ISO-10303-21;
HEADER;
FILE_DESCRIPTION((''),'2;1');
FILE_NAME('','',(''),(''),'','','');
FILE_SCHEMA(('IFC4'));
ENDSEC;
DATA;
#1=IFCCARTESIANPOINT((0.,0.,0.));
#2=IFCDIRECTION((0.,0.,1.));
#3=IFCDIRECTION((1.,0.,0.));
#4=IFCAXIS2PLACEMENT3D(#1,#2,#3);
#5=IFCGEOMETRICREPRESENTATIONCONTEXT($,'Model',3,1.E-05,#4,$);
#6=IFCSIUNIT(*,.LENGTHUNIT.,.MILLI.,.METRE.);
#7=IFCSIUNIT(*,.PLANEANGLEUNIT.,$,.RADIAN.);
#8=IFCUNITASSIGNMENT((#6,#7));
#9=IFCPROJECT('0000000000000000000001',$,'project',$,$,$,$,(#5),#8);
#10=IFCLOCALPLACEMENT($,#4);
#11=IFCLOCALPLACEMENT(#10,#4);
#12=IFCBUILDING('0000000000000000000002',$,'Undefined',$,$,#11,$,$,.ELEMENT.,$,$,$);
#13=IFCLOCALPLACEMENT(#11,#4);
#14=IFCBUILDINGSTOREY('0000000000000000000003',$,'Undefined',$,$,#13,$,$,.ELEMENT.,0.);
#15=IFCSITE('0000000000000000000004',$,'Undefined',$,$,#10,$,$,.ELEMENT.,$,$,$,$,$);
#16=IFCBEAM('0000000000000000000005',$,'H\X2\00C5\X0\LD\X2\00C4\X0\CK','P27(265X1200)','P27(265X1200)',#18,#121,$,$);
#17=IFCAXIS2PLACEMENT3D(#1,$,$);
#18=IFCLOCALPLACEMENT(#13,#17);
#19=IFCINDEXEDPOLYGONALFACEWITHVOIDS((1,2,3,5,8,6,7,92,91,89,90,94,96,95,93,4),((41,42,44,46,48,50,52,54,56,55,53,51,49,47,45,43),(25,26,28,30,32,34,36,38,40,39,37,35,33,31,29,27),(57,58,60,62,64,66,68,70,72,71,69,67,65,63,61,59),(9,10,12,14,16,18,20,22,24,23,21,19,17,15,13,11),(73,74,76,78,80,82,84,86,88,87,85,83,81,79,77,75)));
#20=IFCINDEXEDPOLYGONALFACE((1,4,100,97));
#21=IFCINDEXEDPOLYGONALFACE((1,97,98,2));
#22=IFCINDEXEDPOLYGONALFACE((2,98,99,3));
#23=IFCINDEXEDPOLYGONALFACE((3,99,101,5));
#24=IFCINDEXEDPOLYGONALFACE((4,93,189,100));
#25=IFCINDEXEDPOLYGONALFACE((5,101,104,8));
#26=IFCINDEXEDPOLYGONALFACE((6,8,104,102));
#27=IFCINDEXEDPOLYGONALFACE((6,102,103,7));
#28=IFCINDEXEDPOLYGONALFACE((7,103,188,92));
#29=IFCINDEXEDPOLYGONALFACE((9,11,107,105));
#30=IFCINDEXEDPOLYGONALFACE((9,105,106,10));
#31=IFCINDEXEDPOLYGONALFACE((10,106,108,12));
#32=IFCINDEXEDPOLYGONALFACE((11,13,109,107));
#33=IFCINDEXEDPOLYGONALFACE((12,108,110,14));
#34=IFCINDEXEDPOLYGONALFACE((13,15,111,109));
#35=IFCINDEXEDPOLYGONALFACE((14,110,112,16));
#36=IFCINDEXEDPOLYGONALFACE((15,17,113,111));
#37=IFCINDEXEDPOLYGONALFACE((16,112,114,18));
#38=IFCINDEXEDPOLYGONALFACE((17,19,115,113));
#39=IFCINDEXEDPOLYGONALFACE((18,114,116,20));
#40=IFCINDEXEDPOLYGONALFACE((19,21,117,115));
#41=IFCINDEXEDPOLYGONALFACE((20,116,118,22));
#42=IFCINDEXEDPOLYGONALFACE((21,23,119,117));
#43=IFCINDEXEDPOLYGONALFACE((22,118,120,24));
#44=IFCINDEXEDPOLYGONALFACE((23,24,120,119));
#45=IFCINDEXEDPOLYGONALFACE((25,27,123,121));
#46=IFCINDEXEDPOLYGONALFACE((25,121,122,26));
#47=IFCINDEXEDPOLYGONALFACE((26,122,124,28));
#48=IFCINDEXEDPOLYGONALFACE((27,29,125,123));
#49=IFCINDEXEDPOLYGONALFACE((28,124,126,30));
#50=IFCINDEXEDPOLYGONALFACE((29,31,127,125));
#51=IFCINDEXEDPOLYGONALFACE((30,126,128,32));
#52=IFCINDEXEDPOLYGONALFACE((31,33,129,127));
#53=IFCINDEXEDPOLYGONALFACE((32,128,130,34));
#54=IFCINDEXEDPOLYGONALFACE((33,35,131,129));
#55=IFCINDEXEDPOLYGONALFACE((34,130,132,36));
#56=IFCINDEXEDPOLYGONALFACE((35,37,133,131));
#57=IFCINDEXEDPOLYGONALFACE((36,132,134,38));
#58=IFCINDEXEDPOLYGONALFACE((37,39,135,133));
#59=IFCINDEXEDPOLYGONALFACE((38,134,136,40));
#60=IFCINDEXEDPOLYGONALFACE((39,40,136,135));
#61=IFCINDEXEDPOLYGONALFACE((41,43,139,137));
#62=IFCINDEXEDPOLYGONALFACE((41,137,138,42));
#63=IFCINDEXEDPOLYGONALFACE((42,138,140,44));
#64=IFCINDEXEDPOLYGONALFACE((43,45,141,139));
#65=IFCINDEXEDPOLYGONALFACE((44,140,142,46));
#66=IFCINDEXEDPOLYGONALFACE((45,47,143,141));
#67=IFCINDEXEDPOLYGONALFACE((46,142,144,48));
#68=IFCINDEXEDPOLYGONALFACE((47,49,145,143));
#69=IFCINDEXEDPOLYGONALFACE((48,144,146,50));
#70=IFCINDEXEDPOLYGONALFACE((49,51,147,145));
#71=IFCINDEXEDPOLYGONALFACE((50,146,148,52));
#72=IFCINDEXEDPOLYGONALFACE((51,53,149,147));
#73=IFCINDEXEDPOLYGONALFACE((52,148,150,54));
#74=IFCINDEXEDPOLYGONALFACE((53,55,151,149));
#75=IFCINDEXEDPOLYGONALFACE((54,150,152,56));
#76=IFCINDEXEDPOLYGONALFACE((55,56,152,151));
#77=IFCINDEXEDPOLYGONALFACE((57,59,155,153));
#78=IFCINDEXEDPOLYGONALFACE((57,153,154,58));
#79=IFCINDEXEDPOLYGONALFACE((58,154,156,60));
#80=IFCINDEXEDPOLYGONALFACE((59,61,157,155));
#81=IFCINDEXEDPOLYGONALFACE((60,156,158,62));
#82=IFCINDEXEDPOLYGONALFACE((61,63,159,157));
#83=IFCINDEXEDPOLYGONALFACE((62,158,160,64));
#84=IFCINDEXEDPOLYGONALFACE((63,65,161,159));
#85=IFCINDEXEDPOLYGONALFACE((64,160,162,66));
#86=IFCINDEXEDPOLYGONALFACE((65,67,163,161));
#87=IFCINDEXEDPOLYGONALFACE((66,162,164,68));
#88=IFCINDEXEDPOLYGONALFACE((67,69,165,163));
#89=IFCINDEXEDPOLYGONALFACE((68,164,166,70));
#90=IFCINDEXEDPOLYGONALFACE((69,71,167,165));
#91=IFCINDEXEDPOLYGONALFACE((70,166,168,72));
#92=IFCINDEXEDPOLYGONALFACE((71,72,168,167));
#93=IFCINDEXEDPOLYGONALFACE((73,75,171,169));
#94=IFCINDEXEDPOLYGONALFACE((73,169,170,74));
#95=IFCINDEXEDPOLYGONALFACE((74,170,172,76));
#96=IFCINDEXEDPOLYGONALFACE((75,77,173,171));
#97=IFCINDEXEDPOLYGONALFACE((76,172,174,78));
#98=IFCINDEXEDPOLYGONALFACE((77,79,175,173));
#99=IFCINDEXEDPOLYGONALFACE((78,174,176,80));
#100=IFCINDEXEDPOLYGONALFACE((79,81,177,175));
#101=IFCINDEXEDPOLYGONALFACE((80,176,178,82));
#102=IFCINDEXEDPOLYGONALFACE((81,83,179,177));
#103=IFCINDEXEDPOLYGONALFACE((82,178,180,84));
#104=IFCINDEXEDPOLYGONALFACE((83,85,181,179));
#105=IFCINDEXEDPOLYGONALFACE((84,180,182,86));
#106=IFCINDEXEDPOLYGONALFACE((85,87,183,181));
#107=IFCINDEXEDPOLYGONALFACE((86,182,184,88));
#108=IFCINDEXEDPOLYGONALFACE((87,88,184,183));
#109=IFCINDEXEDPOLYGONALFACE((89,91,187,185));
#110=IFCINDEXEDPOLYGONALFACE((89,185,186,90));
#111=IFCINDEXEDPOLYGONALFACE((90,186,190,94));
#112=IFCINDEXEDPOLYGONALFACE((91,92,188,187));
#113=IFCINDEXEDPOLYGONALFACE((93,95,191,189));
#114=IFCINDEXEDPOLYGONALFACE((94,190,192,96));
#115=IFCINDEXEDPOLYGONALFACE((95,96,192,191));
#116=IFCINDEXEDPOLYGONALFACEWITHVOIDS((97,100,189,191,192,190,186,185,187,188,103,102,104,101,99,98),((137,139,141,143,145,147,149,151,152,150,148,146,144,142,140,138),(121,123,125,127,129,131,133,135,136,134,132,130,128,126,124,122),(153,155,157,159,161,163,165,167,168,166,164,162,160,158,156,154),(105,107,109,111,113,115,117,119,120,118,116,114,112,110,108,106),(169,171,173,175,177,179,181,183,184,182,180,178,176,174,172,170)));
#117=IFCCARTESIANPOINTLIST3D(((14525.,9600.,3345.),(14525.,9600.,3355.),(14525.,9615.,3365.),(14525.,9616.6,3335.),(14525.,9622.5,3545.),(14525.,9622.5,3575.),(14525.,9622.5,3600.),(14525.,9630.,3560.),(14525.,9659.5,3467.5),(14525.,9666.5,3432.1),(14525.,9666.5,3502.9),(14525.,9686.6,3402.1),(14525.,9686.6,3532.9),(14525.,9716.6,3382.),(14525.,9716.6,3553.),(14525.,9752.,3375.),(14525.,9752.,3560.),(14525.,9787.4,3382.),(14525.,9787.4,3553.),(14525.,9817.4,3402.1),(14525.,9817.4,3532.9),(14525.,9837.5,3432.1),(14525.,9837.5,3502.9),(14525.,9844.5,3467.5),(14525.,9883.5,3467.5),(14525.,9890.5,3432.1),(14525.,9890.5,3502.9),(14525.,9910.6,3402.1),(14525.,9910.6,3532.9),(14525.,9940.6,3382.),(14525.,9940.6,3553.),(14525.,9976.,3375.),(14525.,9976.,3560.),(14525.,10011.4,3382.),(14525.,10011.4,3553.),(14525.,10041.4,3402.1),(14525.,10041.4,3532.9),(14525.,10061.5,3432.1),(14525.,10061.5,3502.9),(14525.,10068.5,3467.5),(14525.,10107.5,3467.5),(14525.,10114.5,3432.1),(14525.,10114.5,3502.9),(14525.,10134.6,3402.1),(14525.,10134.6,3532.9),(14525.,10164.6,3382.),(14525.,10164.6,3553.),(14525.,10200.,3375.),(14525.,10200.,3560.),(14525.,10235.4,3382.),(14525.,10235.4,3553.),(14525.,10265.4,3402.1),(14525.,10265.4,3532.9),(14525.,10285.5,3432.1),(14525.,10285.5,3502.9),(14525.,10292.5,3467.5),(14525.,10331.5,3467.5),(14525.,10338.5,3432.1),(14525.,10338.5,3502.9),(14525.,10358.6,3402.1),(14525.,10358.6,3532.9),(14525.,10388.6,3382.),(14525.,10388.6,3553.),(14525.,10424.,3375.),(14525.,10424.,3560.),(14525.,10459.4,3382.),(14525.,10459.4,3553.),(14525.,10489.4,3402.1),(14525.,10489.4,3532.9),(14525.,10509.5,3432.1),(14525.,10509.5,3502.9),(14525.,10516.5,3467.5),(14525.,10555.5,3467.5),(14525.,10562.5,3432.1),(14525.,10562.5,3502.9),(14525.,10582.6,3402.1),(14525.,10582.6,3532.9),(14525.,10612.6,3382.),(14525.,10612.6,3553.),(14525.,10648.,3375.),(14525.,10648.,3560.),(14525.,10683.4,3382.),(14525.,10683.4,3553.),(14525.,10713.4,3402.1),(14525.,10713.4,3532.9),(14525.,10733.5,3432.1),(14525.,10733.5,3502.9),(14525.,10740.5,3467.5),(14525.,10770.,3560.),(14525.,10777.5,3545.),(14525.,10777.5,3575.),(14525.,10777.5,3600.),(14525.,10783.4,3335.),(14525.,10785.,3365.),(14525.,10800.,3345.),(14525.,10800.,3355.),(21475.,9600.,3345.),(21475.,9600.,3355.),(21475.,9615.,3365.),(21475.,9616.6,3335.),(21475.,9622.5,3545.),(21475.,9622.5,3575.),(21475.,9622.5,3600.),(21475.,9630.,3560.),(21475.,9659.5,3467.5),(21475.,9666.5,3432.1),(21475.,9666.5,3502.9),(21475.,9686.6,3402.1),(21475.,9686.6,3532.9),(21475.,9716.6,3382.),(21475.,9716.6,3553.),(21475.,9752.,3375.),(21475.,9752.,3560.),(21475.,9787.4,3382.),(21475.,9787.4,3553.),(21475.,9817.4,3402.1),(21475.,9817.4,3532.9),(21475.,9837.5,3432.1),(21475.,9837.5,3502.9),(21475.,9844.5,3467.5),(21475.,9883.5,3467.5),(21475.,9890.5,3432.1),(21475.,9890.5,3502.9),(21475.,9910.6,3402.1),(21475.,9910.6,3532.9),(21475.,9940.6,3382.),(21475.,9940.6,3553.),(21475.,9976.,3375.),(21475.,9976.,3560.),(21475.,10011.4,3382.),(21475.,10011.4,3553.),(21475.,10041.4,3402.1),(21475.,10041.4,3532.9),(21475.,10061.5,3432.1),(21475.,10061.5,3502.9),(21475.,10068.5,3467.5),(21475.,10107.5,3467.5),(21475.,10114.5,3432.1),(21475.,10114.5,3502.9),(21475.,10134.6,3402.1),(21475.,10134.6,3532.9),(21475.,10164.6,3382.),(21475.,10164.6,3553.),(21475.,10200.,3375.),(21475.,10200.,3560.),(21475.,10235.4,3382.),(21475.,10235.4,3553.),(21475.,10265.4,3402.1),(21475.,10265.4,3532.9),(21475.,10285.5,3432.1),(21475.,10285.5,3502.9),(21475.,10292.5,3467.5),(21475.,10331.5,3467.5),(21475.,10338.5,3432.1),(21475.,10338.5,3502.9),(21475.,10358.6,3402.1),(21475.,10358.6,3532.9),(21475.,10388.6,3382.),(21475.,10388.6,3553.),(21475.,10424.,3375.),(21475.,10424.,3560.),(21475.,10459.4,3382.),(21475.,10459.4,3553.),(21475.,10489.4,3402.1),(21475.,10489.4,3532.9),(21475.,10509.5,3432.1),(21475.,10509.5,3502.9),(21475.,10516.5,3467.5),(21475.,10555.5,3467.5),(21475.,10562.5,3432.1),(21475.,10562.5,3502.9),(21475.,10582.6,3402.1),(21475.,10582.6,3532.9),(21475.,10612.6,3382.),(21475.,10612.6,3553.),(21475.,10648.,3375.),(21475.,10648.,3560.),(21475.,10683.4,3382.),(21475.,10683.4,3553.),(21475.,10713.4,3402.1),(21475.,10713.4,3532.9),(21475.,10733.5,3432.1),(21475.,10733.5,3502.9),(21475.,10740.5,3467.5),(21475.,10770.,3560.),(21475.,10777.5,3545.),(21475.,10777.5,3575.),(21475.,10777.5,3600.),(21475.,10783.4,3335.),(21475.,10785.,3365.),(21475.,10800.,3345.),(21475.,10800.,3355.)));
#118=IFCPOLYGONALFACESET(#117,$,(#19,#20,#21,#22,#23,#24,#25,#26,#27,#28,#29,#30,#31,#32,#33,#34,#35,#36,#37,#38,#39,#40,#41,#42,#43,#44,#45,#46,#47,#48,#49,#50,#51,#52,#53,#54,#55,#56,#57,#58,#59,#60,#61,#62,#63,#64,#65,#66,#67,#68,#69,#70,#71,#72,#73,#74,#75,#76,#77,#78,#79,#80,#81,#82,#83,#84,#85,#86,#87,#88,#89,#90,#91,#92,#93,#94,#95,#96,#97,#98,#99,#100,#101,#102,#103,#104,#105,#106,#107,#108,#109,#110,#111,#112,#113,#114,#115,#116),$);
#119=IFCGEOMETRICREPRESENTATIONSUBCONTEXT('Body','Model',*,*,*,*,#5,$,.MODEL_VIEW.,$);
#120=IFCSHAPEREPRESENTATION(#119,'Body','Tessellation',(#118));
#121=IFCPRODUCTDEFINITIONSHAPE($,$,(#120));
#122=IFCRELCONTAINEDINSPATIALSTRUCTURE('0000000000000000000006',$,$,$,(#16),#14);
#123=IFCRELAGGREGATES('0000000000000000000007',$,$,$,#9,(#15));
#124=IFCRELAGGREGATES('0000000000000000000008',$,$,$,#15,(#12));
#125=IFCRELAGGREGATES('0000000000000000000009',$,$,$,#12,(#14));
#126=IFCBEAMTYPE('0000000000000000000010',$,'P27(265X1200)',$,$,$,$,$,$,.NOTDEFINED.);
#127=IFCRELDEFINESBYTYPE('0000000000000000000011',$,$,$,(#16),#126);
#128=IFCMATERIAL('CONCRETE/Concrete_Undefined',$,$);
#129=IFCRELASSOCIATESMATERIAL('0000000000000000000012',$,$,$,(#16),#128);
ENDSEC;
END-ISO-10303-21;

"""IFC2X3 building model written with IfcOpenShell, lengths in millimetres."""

from ifc_helpers import new_model, si_unit, frame, origin_with_axes, place, context, subcontext, project, spatial, polyline, outline, extrude, material, type_object, element, save


model = new_model("IFC2X3")

# Units and contexts
model_context = context("Model", 3, precision=1e-05, world=origin_with_axes())
body_context = subcontext(model_context, "Body", "Model", "MODEL_VIEW")
ifc_project = project(units=[si_unit("LENGTHUNIT", "METRE", prefix="MILLI"), si_unit("PLANEANGLEUNIT", "RADIAN")], contexts=[model_context])

# Site, building, storey
site_placement = place(None, origin_with_axes())
site = spatial("IfcSite", under=ifc_project, at=site_placement, Name="Undefined", CompositionType="ELEMENT")
building_placement = place(site_placement, origin_with_axes())
building = spatial("IfcBuilding", under=site, at=building_placement, Name="Undefined", CompositionType="ELEMENT")
storey_placement = place(building_placement, origin_with_axes())
storey = spatial("IfcBuildingStorey", under=building, at=storey_placement, Name="Undefined", CompositionType="ELEMENT", Elevation=0.0)

# Beam
ifc_material_1 = material(Name="CONCRETE/Concrete_Undefined")
beam_type_1 = type_object("IfcBeamType", Name="P27(265X1200)", PredefinedType="NOTDEFINED")
beam_1_placement = place(storey_placement, frame((14525.0, 10200.0, 3467.5), z_axis=(0.0, 0.0, 1.0), x_axis=(1.0, 0.0, 0.0)))
element("IfcBeam", 1, at=beam_1_placement, inside=storey, type_object=beam_type_1, material=ifc_material_1, Name="HÅLDÄCK", Description="P27(265X1200)", ObjectType="P27(265X1200)", context=body_context, shape_type="SweptSolid", body=[
    extrude(outline(polyline([(-583.4, -132.5), (-600.0, -122.5), (-600.0, -112.5), (-585.0, -102.5), (-577.5, 77.5), (-570.0, 92.5), (-577.5, 107.5), (-577.5, 132.5), (577.5, 132.5), (577.5, 107.5), (570.0, 92.5), (577.5, 77.5), (585.0, -102.5), (600.0, -112.5), (600.0, -122.5), (583.4, -132.5), (-583.4, -132.5)]), holes=[polyline([(-513.4, 65.4), (-533.5, 35.4), (-540.5, 0.0), (-533.5, -35.4), (-513.4, -65.4), (-483.4, -85.5), (-448.0, -92.5), (-412.6, -85.5), (-382.6, -65.4), (-362.5, -35.4), (-355.5, 0.0), (-362.5, 35.4), (-382.6, 65.4), (-412.6, 85.5), (-448.0, 92.5), (-483.4, 85.5), (-513.4, 65.4)]), polyline([(-289.4, 65.4), (-309.5, 35.4), (-316.5, 0.0), (-309.5, -35.4), (-289.4, -65.4), (-259.4, -85.5), (-224.0, -92.5), (-188.6, -85.5), (-158.6, -65.4), (-138.5, -35.4), (-131.5, 0.0), (-138.5, 35.4), (-158.6, 65.4), (-188.6, 85.5), (-224.0, 92.5), (-259.4, 85.5), (-289.4, 65.4)]), polyline([(-65.4, 65.4), (-85.5, 35.4), (-92.5, 0.0), (-85.5, -35.4), (-65.4, -65.4), (-35.4, -85.5), (0.0, -92.5), (35.4, -85.5), (65.4, -65.4), (85.5, -35.4), (92.5, 0.0), (85.5, 35.4), (65.4, 65.4), (35.4, 85.5), (0.0, 92.5), (-35.4, 85.5), (-65.4, 65.4)]), polyline([(158.6, 65.4), (138.5, 35.4), (131.5, 0.0), (138.5, -35.4), (158.6, -65.4), (188.6, -85.5), (224.0, -92.5), (259.4, -85.5), (289.4, -65.4), (309.5, -35.4), (316.5, 0.0), (309.5, 35.4), (289.4, 65.4), (259.4, 85.5), (224.0, 92.5), (188.6, 85.5), (158.6, 65.4)]), polyline([(382.6, 65.4), (362.5, 35.4), (355.5, 0.0), (362.5, -35.4), (382.6, -65.4), (412.6, -85.5), (448.0, -92.5), (483.4, -85.5), (513.4, -65.4), (533.5, -35.4), (540.5, 0.0), (533.5, 35.4), (513.4, 65.4), (483.4, 85.5), (448.0, 92.5), (412.6, 85.5), (382.6, 65.4)])]), frame((6950.0, 0.0, 0.0), z_axis=(-1.0, 0.0, 0.0), x_axis=(0.0, -1.0, 0.0)), (0.0, 0.0, 1.0), 6950.0),
])

save(model, "model.ifc")
